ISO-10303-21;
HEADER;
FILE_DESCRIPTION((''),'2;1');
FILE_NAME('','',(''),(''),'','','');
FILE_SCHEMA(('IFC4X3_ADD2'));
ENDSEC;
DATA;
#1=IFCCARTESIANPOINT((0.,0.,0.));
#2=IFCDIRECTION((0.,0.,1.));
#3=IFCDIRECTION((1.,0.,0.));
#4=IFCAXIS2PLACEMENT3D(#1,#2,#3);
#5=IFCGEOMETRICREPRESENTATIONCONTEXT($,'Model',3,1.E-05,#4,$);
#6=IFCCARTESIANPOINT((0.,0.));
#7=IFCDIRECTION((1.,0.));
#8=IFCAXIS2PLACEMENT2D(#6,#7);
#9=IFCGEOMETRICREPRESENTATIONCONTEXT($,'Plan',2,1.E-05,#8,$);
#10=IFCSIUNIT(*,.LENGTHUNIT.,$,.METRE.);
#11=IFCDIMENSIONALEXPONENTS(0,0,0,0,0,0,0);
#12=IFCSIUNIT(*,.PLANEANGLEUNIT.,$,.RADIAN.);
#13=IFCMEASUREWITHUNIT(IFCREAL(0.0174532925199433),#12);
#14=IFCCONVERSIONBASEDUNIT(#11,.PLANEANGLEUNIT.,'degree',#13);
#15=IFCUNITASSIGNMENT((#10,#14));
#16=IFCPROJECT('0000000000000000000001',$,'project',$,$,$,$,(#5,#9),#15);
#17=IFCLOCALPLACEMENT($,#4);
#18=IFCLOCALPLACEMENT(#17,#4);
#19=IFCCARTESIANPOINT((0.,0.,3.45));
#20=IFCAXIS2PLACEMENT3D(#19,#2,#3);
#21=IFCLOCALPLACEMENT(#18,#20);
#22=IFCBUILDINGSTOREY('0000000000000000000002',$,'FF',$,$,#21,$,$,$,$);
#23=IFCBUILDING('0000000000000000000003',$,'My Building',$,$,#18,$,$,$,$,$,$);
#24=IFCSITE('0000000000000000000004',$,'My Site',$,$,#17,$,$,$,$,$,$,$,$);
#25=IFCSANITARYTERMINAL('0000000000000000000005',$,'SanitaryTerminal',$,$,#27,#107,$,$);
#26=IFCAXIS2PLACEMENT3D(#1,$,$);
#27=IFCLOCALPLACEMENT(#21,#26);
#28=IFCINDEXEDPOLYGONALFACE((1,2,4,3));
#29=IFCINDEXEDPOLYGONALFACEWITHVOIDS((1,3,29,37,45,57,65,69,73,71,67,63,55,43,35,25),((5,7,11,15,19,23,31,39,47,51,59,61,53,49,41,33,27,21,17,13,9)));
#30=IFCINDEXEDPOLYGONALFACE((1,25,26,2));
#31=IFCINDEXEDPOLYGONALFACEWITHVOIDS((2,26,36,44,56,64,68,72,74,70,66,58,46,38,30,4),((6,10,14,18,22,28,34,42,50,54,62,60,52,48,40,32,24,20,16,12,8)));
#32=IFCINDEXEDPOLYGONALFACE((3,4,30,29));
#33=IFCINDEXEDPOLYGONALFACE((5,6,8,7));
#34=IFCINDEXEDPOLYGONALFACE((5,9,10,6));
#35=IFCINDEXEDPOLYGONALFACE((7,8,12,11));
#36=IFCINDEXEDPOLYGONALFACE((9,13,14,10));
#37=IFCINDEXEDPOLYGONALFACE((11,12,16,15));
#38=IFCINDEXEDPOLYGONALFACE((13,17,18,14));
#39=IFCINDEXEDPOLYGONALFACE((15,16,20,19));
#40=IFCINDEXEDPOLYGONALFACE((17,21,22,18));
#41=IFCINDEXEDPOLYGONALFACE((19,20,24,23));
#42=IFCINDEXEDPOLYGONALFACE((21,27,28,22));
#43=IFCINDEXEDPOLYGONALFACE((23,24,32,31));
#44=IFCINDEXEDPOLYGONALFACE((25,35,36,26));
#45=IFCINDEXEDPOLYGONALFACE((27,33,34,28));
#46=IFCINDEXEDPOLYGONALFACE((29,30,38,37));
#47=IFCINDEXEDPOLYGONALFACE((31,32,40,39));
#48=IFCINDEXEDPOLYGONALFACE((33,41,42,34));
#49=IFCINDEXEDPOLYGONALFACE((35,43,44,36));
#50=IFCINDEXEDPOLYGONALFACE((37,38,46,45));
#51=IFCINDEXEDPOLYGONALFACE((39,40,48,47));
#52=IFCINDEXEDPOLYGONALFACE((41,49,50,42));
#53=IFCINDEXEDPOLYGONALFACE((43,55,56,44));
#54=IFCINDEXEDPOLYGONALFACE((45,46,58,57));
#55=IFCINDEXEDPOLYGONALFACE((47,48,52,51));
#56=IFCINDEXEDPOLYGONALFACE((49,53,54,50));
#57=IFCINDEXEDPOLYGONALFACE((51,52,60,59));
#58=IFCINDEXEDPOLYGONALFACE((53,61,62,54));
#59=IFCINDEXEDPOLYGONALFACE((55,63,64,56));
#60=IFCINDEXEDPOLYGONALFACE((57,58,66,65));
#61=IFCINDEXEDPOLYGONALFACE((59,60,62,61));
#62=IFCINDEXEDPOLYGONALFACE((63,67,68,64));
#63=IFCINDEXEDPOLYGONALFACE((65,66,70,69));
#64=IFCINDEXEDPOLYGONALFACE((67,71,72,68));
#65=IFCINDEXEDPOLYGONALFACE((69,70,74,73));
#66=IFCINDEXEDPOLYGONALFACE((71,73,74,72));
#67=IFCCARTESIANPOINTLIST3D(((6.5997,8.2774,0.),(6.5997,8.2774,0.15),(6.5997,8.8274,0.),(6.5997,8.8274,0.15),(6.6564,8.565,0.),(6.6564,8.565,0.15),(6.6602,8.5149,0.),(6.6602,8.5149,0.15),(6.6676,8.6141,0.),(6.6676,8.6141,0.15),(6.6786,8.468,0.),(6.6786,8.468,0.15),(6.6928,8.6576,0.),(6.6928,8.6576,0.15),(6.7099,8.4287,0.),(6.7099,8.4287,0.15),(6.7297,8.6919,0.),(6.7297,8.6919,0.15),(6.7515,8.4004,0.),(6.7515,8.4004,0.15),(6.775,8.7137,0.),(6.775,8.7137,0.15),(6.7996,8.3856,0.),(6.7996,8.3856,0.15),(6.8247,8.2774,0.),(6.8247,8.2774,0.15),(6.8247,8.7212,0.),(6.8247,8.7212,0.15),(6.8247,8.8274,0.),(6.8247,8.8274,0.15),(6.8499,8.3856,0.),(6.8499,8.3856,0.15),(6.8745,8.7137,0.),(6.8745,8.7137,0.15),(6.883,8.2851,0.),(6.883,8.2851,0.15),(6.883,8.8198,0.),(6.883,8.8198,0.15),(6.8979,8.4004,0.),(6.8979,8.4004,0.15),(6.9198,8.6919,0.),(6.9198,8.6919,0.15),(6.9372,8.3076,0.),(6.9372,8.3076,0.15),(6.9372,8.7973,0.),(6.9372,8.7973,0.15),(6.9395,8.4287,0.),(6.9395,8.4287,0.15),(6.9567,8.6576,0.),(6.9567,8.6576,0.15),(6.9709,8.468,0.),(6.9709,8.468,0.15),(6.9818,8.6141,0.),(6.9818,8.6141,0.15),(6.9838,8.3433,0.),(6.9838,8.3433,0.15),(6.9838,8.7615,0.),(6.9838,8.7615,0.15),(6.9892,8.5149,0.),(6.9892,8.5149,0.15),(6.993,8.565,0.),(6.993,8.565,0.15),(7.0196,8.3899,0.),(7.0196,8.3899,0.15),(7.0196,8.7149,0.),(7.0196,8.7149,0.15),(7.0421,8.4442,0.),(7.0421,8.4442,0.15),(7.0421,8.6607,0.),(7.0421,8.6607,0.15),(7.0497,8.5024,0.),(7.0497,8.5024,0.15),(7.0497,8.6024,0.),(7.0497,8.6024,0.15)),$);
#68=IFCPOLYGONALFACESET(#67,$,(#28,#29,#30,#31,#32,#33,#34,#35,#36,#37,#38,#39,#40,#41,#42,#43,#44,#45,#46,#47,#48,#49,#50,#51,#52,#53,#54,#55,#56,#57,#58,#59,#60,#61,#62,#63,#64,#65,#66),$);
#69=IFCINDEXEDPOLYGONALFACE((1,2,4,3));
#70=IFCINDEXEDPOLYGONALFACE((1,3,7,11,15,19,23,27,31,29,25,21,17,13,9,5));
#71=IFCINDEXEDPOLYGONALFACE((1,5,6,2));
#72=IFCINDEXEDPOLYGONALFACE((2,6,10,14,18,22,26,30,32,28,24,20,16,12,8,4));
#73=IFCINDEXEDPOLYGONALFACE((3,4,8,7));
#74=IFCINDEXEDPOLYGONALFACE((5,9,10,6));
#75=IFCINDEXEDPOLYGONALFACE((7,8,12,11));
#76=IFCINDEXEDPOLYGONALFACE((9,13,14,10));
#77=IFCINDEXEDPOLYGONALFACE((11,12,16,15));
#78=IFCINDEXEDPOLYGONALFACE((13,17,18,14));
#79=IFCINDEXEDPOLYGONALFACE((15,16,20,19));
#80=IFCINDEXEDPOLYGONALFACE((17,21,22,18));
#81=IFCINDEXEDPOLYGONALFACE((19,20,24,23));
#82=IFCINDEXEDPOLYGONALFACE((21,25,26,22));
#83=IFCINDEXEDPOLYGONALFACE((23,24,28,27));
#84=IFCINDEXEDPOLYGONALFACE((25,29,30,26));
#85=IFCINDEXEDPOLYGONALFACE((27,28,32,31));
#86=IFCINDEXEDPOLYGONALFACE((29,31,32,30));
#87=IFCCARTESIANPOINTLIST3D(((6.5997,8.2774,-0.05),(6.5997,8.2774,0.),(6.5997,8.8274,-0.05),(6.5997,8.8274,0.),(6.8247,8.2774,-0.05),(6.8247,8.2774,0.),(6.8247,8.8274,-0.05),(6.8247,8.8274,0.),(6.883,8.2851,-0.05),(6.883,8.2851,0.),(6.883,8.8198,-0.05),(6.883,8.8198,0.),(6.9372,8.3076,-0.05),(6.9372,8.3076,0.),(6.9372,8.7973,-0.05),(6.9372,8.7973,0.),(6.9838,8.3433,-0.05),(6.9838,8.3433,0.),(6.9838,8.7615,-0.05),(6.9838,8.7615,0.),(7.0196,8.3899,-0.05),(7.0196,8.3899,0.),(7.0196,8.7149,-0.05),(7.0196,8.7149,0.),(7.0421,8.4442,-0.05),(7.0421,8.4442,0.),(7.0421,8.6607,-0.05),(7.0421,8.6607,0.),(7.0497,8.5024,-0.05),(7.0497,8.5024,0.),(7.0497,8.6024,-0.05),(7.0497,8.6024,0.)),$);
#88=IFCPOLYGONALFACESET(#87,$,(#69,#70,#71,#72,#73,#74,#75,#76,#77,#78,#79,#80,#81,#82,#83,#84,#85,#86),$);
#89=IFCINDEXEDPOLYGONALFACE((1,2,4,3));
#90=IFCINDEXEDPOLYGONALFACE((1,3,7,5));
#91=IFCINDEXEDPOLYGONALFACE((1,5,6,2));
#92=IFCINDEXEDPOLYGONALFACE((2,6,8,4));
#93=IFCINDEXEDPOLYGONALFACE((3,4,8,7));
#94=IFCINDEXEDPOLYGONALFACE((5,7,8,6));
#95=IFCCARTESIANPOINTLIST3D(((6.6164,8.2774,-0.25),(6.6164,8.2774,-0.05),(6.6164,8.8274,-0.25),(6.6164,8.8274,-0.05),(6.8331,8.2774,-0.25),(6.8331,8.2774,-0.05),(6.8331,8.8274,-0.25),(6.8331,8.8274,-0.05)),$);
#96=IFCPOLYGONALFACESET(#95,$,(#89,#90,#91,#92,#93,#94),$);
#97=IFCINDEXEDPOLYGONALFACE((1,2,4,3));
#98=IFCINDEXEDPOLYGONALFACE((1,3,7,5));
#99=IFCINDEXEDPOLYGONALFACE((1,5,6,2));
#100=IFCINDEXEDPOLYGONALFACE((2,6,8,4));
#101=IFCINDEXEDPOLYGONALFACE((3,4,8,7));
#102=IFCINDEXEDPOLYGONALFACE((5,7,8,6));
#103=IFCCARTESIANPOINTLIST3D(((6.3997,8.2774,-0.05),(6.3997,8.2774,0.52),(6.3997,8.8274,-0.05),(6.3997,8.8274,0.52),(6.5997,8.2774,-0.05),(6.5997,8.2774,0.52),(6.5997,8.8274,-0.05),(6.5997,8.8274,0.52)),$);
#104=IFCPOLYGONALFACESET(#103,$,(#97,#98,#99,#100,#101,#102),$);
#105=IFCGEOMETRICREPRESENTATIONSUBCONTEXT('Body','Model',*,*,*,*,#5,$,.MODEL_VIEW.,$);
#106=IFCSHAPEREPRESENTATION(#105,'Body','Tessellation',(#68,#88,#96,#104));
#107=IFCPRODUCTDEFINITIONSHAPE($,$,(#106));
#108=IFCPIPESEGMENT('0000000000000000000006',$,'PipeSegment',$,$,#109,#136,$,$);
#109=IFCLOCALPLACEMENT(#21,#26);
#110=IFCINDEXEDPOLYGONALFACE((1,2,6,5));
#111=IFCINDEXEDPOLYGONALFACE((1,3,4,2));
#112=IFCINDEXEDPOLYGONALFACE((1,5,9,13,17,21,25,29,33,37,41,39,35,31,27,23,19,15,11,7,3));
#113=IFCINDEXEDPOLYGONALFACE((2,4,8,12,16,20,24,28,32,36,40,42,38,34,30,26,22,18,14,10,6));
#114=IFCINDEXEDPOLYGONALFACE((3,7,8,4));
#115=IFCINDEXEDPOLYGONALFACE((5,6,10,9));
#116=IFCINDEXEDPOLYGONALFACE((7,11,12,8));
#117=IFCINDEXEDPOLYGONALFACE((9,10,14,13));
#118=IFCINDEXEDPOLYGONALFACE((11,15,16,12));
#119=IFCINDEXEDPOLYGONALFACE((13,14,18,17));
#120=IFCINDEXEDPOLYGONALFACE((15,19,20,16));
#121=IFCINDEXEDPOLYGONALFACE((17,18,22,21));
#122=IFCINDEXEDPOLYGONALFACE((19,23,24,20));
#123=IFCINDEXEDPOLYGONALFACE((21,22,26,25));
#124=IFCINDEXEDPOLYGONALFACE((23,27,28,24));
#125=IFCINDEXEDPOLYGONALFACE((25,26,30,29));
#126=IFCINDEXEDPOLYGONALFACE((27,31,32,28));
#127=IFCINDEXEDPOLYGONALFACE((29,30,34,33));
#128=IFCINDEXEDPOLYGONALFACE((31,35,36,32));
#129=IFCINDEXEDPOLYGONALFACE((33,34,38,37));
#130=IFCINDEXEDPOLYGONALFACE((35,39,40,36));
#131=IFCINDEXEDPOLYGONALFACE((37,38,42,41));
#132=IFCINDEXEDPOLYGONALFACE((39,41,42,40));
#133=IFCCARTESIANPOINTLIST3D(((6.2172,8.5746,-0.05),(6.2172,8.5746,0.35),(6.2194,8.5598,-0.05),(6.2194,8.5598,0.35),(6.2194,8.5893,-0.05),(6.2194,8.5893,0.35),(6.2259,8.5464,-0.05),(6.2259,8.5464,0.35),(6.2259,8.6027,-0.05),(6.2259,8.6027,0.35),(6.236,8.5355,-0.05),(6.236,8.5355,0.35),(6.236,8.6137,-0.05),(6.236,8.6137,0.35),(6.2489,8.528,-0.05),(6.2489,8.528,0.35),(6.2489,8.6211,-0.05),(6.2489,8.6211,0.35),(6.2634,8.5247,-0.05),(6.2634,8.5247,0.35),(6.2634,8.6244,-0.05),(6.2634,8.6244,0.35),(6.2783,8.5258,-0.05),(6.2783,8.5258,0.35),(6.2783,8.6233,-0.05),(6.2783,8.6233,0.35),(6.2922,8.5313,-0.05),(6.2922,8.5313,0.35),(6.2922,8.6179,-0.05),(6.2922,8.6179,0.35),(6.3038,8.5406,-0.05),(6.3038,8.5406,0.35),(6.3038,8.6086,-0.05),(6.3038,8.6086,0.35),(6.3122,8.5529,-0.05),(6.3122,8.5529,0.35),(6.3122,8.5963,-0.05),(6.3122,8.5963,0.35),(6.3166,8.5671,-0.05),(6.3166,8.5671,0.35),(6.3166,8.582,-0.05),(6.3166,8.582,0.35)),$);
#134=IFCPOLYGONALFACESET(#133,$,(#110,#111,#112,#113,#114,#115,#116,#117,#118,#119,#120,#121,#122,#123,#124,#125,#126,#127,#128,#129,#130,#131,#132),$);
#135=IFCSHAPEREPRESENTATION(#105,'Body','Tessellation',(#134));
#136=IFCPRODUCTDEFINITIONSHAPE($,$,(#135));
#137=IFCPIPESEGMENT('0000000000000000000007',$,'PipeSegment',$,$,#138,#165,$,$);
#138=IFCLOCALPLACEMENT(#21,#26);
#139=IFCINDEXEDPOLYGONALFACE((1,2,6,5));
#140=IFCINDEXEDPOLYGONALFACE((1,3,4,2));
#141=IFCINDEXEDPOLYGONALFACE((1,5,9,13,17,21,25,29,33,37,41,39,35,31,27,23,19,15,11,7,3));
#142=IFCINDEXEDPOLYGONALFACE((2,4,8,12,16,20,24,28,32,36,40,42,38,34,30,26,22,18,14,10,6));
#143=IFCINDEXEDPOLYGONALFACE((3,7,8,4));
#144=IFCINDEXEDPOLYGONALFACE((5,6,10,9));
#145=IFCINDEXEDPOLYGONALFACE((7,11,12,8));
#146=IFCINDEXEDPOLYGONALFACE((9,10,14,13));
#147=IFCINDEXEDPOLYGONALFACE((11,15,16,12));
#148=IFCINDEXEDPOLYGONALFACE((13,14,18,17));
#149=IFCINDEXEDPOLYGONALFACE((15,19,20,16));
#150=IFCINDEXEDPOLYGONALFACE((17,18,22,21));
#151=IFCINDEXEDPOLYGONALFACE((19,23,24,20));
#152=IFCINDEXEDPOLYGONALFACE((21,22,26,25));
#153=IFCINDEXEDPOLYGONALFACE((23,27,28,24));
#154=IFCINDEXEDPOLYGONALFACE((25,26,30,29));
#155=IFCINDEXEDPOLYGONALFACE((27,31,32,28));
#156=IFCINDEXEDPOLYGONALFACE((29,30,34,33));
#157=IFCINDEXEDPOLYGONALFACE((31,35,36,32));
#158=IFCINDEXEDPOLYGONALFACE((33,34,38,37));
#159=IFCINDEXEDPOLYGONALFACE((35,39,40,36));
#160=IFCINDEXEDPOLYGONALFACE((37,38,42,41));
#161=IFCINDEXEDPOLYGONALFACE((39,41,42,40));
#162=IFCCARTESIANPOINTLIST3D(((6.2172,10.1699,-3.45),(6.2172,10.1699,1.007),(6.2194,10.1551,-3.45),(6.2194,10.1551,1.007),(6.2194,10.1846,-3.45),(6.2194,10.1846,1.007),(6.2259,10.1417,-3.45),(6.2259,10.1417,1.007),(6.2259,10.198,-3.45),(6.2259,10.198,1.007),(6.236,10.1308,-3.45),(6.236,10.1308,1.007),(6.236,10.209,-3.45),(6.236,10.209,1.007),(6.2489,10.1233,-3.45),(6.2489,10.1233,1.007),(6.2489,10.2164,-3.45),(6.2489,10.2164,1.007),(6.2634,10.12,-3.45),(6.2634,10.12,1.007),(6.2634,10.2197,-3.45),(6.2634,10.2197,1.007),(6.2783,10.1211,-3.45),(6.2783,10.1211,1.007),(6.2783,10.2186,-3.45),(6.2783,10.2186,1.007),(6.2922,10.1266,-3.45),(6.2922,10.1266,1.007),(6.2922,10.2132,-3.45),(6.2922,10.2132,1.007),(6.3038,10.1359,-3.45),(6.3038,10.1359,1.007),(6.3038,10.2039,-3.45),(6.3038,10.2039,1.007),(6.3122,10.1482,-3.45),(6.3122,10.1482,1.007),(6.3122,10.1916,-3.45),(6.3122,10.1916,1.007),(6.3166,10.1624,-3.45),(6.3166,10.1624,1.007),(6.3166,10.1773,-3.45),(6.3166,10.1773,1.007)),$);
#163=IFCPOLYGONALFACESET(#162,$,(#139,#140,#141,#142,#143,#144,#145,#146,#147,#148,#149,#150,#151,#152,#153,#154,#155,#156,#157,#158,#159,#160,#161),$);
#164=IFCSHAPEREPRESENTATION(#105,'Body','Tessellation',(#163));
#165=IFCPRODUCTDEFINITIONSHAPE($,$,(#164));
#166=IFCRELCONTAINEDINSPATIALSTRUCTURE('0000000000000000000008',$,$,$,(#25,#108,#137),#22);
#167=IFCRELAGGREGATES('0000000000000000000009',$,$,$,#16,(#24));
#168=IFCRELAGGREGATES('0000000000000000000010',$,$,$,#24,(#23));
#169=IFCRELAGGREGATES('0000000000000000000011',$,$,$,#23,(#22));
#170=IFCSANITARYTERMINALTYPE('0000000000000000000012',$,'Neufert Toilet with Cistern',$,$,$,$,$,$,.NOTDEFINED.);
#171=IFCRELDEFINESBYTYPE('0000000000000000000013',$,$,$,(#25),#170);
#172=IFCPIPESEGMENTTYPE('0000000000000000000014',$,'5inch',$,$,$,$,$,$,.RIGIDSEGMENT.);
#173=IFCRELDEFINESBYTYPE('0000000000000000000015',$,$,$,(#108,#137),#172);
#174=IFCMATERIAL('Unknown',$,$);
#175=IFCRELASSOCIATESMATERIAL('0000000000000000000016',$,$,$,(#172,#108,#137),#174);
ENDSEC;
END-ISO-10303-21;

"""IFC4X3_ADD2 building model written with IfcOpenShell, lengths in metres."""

from ifc_helpers import new_model, entity, si_unit, converted_unit, frame, frame_2d, origin_with_axes, origin_2d_with_axis, place, context, subcontext, project, spatial, line, arc, indexed_curve, circle_curve, circle, outline, extrude, shape, source, transform, mapped, material, material_profile, profile_set, profile_usage, type_object, type_shapes, element, save


model = new_model("IFC4X3_ADD2")

# Units and contexts
model_context = context("Model", 3, precision=1e-05, world=origin_with_axes())
plan_context = context("Plan", 2, precision=1e-05, world=origin_2d_with_axis())
body_context_1 = subcontext(model_context, "Body", "Model", "MODEL_VIEW")
body_context_2 = subcontext(plan_context, "Body", "Plan", "PLAN_VIEW")
ifc_project = project(units=[si_unit("LENGTHUNIT", "METRE"), converted_unit("PLANEANGLEUNIT", "degree", entity("IfcReal", 0.0174532925199433), si_unit("PLANEANGLEUNIT", "RADIAN"), dimensions=[0, 0, 0, 0, 0, 0, 0])], contexts=[model_context, plan_context])

# Site, building, storey
site_placement = place(None, origin_with_axes())
site = spatial("IfcSite", under=ifc_project, at=site_placement, Name="My Site")
building_placement = place(site_placement, origin_with_axes())
building = spatial("IfcBuilding", under=site, at=building_placement, Name="My Building")
storey_placement = place(building_placement, frame((0.0, 0.0, 3.45), z_axis=(0.0, 0.0, 1.0), x_axis=(1.0, 0.0, 0.0)))
storey = spatial("IfcBuildingStorey", under=building, at=storey_placement, Name="FF")

# Shared definitions
ifc_material_1 = material(Name="Unknown")

# Sanitary terminal
sanitary_terminal_type_1 = type_object("IfcSanitaryTerminalType", Name="Neufert Toilet with Cistern", PredefinedType="NOTDEFINED")
shared_shape_1 = source(origin_with_axes(), body_context_1, "Body", "SweptSolid", [
    extrude(outline(indexed_curve([(-0.275, -0.2), (0.275, -0.2), (0.275, -0.425), (0.2091, -0.5841), (0.05, -0.65), (-0.05, -0.65), (-0.2091, -0.5841), (-0.275, -0.425), (0.0, -0.5938), (0.0, -0.2563)], segments=[arc(8, 7, 6), line(6, 5), arc(5, 4, 3), line(3, 2), line(2, 1), line(1, 8)], self_intersect=False), holes=[circle_curve(frame_2d((0.0, -0.425)), 0.1687)]), frame((0.0, 0.0, 0.25), z_axis=(0.0, 0.0, 1.0), x_axis=(1.0, 0.0, 0.0)), (0.0, 0.0, 1.0), 0.15),
    extrude(outline(indexed_curve([(-0.275, -0.2), (0.275, -0.2), (0.275, -0.425), (0.2091, -0.5841), (0.05, -0.65), (-0.05, -0.65), (-0.2091, -0.5841), (-0.275, -0.425)], segments=[line(1, 2), line(2, 3), arc(3, 4, 5), line(5, 6), arc(6, 7, 8), line(8, 1)])), frame((0.0, 0.0, 0.2), z_axis=(0.0, 0.0, 1.0), x_axis=(1.0, 0.0, 0.0)), (0.0, 0.0, 1.0), 0.05),
    extrude(outline(indexed_curve([(-0.275, -0.2167), (0.275, -0.2167), (0.275, -0.4333), (-0.275, -0.4333)], segments=[line(1, 2, 3, 4, 1)])), origin_with_axes(), (0.0, 0.0, 1.0), 0.2),
    extrude(outline(indexed_curve([(-0.275, 0.0), (0.275, 0.0), (0.275, -0.2), (-0.275, -0.2)], segments=[line(1, 2, 3, 4, 1)])), frame((0.0, 0.0, 0.2), z_axis=(0.0, 0.0, 1.0), x_axis=(1.0, 0.0, 0.0)), (0.0, 0.0, 1.0), 0.57),
])
shared_shape_2 = source(origin_with_axes(), body_context_2, "Body", "Curve2D", [
    entity("IfcIndexedPolyCurve", entity("IfcCartesianPointList2D", [[-0.275, 0.0], [0.275, 0.0], [0.275, -0.2], [-0.275, -0.2]]), [entity("IfcLineIndex", [1, 2, 3, 4, 1])]),
    entity("IfcIndexedPolyCurve", entity("IfcCartesianPointList2D", [[0.165, -0.2], [0.1925, -0.335]])),
    entity("IfcTrimmedCurve", entity("IfcEllipse", entity("IfcAxis2Placement2D", entity("IfcCartesianPoint", [0.0, -0.335]), entity("IfcDirection", [1.0, 0.0])), 0.1925, 0.315), [entity("IfcCartesianPoint", [-0.1925, -0.335])], [entity("IfcCartesianPoint", [0.1925, -0.335])], True, "CARTESIAN"),
    entity("IfcIndexedPolyCurve", entity("IfcCartesianPointList2D", [[-0.165, -0.2], [-0.1925, -0.335]])),
    entity("IfcEllipse", entity("IfcAxis2Placement2D", entity("IfcCartesianPoint", [0.0, -0.452]), entity("IfcDirection", [1.0, 0.0])), 0.1313, 0.1575),
    entity("IfcIndexedPolyCurve", entity("IfcCartesianPointList2D", [[-0.0344, -0.452], [-0.0344, -0.4295], [0.0344, -0.4295], [0.0344, -0.452]])),
    entity("IfcTrimmedCurve", entity("IfcEllipse", entity("IfcAxis2Placement2D", entity("IfcCartesianPoint", [0.0, -0.452]), entity("IfcDirection", [1.0, 0.0])), 0.0344, 0.0225), [entity("IfcCartesianPoint", [-0.0344, -0.452])], [entity("IfcCartesianPoint", [0.0344, -0.452])], True, "CARTESIAN"),
])
type_shapes(sanitary_terminal_type_1, [shared_shape_1, shared_shape_2])
sanitary_terminal_1_placement = place(storey_placement, frame((6.3997, 8.5524, -0.25), z_axis=(0.0, 0.0, 1.0), x_axis=(0.0, 1.0, 0.0)))
element("IfcSanitaryTerminal", 1, at=sanitary_terminal_1_placement, inside=storey, type_object=sanitary_terminal_type_1, Name="SanitaryTerminal", shapes=[
    shape(body_context_1, "Body", "MappedRepresentation", [mapped(shared_shape_1, transform((0.0, 0.0, 0.0), x_axis=(1.0, 0.0, 0.0), y_axis=(0.0, 1.0, 0.0), z_axis=(0.0, 0.0, 1.0), scale=1.0))]),
    shape(body_context_2, "Body", "MappedRepresentation", [mapped(shared_shape_2, transform((0.0, 0.0, 0.0), x_axis=(1.0, 0.0, 0.0), y_axis=(0.0, 1.0, 0.0), z_axis=(0.0, 0.0, 1.0), scale=1.0))]),
])

# Pipe segments
ifc_material_profile_1 = material_profile(ifc_material_1, circle(Radius=0.05))
ifc_profile_set_1 = profile_set([ifc_material_profile_1])
ifc_profile_usage_1 = profile_usage(ifc_profile_set_1, cardinal=5)
pipe_segment_type_1 = type_object("IfcPipeSegmentType", Name="5inch", PredefinedType="RIGIDSEGMENT", material=ifc_profile_set_1)
pipe_segment_1_placement = place(storey_placement, frame((6.2672, 8.5746, -0.05), z_axis=(0.0, 0.0, 1.0), x_axis=(-1.0, 0.0, 0.0)))
element("IfcPipeSegment", 2, at=pipe_segment_1_placement, inside=storey, type_object=pipe_segment_type_1, material=ifc_profile_usage_1, Name="PipeSegment", context=body_context_1, shape_type="SweptSolid", body=[
    extrude(circle(Radius=0.05), origin_with_axes(), (0.0, 0.0, 1.0), 0.4),
])
ifc_profile_usage_2 = profile_usage(ifc_profile_set_1, cardinal=5)
pipe_segment_2_placement = place(storey_placement, frame((6.2672, 10.1699, -3.45), z_axis=(0.0, 0.0, 1.0), x_axis=(-1.0, 0.0, 0.0)))
element("IfcPipeSegment", 3, at=pipe_segment_2_placement, inside=storey, type_object=pipe_segment_type_1, material=ifc_profile_usage_2, Name="PipeSegment", context=body_context_1, shape_type="SweptSolid", body=[
    extrude(circle(Radius=0.05), origin_with_axes(), (0.0, 0.0, 1.0), 4.457),
])

save(model, "model.ifc")
